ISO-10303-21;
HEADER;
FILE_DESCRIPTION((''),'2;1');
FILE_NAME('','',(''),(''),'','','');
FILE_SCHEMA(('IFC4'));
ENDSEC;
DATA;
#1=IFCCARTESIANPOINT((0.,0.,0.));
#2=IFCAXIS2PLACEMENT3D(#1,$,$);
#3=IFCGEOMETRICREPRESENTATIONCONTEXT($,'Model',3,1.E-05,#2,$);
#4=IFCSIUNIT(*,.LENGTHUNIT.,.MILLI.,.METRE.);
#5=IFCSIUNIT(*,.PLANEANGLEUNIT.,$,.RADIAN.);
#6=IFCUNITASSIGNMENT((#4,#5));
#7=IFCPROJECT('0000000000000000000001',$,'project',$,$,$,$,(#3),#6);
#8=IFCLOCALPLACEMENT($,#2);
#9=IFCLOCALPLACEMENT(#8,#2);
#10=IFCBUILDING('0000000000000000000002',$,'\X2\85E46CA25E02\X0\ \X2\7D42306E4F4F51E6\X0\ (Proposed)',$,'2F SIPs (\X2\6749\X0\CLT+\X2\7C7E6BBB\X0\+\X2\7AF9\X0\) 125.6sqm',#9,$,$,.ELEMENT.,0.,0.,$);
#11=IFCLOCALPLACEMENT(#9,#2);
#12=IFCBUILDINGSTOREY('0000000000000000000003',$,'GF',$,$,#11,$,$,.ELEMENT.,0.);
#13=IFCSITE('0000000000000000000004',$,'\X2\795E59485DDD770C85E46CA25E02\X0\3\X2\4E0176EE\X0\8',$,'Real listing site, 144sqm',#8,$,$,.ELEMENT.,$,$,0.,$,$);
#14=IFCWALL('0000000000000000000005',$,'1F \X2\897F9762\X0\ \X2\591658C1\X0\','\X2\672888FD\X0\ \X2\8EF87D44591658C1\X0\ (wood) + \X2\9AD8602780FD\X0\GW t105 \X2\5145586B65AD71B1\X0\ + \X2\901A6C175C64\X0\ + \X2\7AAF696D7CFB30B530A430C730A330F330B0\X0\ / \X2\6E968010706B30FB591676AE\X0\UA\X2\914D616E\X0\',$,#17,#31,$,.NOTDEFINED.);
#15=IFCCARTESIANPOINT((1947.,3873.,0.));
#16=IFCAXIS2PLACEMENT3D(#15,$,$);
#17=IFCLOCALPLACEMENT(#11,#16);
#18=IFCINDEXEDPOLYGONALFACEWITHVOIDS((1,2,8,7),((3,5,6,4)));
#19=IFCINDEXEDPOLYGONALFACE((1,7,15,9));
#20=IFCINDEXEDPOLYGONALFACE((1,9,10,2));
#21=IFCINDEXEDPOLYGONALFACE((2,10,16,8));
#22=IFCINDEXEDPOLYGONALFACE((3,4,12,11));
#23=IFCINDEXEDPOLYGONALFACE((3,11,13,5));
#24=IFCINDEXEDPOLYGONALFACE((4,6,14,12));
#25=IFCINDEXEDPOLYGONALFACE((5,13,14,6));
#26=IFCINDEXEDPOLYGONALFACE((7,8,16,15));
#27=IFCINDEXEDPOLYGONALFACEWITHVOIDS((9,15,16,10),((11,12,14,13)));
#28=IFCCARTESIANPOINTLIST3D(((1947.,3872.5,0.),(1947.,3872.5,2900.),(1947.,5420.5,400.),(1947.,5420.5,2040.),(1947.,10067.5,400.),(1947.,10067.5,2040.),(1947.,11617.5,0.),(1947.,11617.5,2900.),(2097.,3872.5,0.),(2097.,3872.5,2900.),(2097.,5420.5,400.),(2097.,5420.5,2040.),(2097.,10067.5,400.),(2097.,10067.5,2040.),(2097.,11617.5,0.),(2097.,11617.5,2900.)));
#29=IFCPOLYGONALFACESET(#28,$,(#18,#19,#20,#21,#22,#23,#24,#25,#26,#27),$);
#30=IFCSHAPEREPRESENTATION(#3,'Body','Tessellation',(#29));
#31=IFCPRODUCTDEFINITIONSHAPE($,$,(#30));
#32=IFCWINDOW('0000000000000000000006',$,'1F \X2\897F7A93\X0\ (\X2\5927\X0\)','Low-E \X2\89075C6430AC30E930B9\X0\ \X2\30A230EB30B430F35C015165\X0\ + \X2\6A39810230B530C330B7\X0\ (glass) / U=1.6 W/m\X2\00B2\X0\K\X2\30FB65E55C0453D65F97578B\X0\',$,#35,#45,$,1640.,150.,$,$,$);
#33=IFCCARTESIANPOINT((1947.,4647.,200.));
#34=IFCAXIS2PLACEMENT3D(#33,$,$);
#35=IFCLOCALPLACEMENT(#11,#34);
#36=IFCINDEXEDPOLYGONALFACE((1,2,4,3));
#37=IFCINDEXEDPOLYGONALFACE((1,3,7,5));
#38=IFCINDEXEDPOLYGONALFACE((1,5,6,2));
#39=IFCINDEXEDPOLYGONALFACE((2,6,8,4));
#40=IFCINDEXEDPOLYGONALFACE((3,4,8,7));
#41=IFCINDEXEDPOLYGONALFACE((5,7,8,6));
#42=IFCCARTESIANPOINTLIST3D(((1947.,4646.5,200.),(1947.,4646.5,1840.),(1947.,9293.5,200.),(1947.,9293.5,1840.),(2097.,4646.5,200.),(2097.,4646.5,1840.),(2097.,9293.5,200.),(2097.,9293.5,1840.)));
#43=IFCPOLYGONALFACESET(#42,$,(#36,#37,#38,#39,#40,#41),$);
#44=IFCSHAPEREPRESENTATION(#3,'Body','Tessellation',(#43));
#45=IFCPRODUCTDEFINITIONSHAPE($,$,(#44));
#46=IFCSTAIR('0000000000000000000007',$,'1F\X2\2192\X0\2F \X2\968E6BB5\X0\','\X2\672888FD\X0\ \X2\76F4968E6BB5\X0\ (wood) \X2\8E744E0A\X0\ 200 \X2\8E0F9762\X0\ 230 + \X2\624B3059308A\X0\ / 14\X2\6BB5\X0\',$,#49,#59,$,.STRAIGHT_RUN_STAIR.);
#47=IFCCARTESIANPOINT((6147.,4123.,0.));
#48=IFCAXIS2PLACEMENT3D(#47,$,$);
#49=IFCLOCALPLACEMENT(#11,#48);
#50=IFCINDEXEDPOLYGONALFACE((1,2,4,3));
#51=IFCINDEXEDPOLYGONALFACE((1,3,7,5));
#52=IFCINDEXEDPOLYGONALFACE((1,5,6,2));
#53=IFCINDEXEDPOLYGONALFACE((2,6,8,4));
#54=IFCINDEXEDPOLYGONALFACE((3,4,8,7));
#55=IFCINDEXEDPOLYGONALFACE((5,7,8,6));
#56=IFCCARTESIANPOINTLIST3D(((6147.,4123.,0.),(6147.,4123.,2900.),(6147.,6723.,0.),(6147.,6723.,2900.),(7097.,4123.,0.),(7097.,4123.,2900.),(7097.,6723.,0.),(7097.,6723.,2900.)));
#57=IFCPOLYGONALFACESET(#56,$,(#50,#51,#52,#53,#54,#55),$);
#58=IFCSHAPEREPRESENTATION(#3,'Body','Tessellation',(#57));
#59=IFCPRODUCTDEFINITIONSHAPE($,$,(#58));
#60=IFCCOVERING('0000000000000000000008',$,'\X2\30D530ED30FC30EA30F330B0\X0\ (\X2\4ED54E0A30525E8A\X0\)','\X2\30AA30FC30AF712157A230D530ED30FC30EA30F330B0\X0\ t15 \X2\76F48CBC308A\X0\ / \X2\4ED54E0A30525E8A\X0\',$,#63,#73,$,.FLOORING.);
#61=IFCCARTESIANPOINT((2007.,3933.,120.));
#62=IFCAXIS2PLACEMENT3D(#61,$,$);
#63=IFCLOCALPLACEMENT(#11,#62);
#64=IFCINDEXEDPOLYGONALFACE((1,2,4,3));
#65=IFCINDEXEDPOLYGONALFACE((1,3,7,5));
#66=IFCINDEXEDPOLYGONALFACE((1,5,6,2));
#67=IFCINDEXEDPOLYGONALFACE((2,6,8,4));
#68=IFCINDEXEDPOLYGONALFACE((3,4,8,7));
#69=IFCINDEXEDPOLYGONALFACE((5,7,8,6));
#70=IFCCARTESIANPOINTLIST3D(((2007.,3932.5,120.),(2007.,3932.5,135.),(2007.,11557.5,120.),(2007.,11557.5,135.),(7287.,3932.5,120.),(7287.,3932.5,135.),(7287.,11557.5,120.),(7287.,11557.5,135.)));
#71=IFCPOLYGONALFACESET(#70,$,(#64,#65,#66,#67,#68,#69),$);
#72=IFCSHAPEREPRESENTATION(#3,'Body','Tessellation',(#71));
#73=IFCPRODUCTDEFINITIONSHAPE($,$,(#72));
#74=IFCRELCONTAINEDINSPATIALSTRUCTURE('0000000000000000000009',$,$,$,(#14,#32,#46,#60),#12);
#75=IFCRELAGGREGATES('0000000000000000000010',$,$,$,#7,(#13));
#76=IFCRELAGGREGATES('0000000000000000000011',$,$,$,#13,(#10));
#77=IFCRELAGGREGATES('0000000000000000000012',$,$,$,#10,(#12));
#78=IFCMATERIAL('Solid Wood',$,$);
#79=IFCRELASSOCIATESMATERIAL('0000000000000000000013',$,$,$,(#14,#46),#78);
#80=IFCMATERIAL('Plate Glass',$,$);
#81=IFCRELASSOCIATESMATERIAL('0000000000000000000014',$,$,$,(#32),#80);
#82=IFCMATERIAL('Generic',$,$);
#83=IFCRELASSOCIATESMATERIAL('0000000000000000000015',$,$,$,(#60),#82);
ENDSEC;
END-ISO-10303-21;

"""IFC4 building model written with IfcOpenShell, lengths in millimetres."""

from ifc_helpers import new_model, si_unit, frame, frame_2d, origin, place, context, project, spatial, rectangle, extrude, material, element, fill, save


model = new_model("IFC4")

# Units and contexts
model_context = context("Model", 3, precision=1e-05, world=origin())
ifc_project = project(units=[si_unit("LENGTHUNIT", "METRE", prefix="MILLI"), si_unit("PLANEANGLEUNIT", "RADIAN")], contexts=[model_context])

# Site, building, storey
site_placement = place(None, origin())
site = spatial("IfcSite", under=ifc_project, at=site_placement, Name="神奈川県藤沢市3丁目8", ObjectType="Real listing site, 144sqm", CompositionType="ELEMENT", RefElevation=0.0)
building_placement = place(site_placement, origin())
building = spatial("IfcBuilding", under=site, at=building_placement, Name="藤沢市 終の住処 (Proposed)", ObjectType="2F SIPs (杉CLT+籾殻+竹) 125.6sqm", CompositionType="ELEMENT", ElevationOfRefHeight=0.0, ElevationOfTerrain=0.0)
storey_placement = place(building_placement, origin())
storey = spatial("IfcBuildingStorey", under=building, at=storey_placement, Name="GF", CompositionType="ELEMENT", Elevation=0.0)

# Shared definitions
ifc_material_1 = material(Name="Solid Wood")
ifc_material_2 = material(Name="Generic")

# Shared definitions
ifc_material_3 = material(Name="Plate Glass")

# Wall, opening, window
wall_1_placement = place(storey_placement, frame((1947.0, 3873.0, 0.0)))
wall_1 = element("IfcWall", 1, at=wall_1_placement, inside=storey, material=ifc_material_1, Name="1F 西面 外壁", Description="木製 軸組外壁 (wood) + 高性能GW t105 充填断熱 + 通気層 + 窯業系サイディング / 準耐火・外皮UA配慮", PredefinedType="NOTDEFINED", context=model_context, shape_type="SweptSolid", body=[
    extrude(rectangle(XDim=150.0, YDim=7745.0, at=frame_2d((75.0, 3872.0))), frame((1947.0, 3873.0, 0.0)), (0.0, 0.0, 1.0), 2900.0),
])
opening_1_placement = place(storey_placement, frame((1947.0, 4647.0, 200.0)))
opening_1 = element("IfcOpeningElement", 2, at=opening_1_placement, cuts=wall_1, PredefinedType="NOTDEFINED", context=model_context, shape_type="SweptSolid", body=[
    extrude(rectangle(XDim=150.0, YDim=4647.0, at=frame_2d((75.0, 2323.0))), frame((1947.0, 4647.0, 200.0)), (0.0, 0.0, 1.0), 1640.0),
])
window_1_placement = place(storey_placement, frame((1947.0, 4647.0, 200.0)))
window_1 = element("IfcWindow", 3, at=window_1_placement, inside=storey, material=ifc_material_3, Name="1F 西窓 (大)", Description="Low-E 複層ガラス アルゴン封入 + 樹脂サッシ (glass) / U=1.6 W/m²K・日射取得型", OverallHeight=1640.0, OverallWidth=150.0, context=model_context, shape_type="SweptSolid", body=[
    extrude(rectangle(XDim=150.0, YDim=4647.0, at=frame_2d((75.0, 2323.0))), frame((1947.0, 4647.0, 200.0)), (0.0, 0.0, 1.0), 1640.0),
])
fill(opening_1, window_1)

# Stair
stair_placement = place(storey_placement, frame((6147.0, 4123.0, 0.0)))
element("IfcStair", 4, at=stair_placement, inside=storey, material=ifc_material_1, Name="1F→2F 階段", Description="木製 直階段 (wood) 蹴上 200 踏面 230 + 手すり / 14段", PredefinedType="STRAIGHT_RUN_STAIR", context=model_context, shape_type="SweptSolid", body=[
    extrude(rectangle(XDim=950.0, YDim=2600.0, at=frame_2d((475.0, 1300.0))), frame((6147.0, 4123.0, 0.0)), (0.0, 0.0, 1.0), 2900.0),
])

# Covering
covering_placement = place(storey_placement, frame((2007.0, 3933.0, 120.0)))
element("IfcCovering", 5, at=covering_placement, inside=storey, material=ifc_material_2, Name="フローリング (仕上げ床)", Description="オーク無垢フローリング t15 直貼り / 仕上げ床", PredefinedType="FLOORING", context=model_context, shape_type="SweptSolid", body=[
    extrude(rectangle(XDim=5280.0, YDim=7625.0, at=frame_2d((2640.0, 3812.0))), frame((2007.0, 3933.0, 120.0)), (0.0, 0.0, 1.0), 15.0),
])

save(model, "model.ifc")
